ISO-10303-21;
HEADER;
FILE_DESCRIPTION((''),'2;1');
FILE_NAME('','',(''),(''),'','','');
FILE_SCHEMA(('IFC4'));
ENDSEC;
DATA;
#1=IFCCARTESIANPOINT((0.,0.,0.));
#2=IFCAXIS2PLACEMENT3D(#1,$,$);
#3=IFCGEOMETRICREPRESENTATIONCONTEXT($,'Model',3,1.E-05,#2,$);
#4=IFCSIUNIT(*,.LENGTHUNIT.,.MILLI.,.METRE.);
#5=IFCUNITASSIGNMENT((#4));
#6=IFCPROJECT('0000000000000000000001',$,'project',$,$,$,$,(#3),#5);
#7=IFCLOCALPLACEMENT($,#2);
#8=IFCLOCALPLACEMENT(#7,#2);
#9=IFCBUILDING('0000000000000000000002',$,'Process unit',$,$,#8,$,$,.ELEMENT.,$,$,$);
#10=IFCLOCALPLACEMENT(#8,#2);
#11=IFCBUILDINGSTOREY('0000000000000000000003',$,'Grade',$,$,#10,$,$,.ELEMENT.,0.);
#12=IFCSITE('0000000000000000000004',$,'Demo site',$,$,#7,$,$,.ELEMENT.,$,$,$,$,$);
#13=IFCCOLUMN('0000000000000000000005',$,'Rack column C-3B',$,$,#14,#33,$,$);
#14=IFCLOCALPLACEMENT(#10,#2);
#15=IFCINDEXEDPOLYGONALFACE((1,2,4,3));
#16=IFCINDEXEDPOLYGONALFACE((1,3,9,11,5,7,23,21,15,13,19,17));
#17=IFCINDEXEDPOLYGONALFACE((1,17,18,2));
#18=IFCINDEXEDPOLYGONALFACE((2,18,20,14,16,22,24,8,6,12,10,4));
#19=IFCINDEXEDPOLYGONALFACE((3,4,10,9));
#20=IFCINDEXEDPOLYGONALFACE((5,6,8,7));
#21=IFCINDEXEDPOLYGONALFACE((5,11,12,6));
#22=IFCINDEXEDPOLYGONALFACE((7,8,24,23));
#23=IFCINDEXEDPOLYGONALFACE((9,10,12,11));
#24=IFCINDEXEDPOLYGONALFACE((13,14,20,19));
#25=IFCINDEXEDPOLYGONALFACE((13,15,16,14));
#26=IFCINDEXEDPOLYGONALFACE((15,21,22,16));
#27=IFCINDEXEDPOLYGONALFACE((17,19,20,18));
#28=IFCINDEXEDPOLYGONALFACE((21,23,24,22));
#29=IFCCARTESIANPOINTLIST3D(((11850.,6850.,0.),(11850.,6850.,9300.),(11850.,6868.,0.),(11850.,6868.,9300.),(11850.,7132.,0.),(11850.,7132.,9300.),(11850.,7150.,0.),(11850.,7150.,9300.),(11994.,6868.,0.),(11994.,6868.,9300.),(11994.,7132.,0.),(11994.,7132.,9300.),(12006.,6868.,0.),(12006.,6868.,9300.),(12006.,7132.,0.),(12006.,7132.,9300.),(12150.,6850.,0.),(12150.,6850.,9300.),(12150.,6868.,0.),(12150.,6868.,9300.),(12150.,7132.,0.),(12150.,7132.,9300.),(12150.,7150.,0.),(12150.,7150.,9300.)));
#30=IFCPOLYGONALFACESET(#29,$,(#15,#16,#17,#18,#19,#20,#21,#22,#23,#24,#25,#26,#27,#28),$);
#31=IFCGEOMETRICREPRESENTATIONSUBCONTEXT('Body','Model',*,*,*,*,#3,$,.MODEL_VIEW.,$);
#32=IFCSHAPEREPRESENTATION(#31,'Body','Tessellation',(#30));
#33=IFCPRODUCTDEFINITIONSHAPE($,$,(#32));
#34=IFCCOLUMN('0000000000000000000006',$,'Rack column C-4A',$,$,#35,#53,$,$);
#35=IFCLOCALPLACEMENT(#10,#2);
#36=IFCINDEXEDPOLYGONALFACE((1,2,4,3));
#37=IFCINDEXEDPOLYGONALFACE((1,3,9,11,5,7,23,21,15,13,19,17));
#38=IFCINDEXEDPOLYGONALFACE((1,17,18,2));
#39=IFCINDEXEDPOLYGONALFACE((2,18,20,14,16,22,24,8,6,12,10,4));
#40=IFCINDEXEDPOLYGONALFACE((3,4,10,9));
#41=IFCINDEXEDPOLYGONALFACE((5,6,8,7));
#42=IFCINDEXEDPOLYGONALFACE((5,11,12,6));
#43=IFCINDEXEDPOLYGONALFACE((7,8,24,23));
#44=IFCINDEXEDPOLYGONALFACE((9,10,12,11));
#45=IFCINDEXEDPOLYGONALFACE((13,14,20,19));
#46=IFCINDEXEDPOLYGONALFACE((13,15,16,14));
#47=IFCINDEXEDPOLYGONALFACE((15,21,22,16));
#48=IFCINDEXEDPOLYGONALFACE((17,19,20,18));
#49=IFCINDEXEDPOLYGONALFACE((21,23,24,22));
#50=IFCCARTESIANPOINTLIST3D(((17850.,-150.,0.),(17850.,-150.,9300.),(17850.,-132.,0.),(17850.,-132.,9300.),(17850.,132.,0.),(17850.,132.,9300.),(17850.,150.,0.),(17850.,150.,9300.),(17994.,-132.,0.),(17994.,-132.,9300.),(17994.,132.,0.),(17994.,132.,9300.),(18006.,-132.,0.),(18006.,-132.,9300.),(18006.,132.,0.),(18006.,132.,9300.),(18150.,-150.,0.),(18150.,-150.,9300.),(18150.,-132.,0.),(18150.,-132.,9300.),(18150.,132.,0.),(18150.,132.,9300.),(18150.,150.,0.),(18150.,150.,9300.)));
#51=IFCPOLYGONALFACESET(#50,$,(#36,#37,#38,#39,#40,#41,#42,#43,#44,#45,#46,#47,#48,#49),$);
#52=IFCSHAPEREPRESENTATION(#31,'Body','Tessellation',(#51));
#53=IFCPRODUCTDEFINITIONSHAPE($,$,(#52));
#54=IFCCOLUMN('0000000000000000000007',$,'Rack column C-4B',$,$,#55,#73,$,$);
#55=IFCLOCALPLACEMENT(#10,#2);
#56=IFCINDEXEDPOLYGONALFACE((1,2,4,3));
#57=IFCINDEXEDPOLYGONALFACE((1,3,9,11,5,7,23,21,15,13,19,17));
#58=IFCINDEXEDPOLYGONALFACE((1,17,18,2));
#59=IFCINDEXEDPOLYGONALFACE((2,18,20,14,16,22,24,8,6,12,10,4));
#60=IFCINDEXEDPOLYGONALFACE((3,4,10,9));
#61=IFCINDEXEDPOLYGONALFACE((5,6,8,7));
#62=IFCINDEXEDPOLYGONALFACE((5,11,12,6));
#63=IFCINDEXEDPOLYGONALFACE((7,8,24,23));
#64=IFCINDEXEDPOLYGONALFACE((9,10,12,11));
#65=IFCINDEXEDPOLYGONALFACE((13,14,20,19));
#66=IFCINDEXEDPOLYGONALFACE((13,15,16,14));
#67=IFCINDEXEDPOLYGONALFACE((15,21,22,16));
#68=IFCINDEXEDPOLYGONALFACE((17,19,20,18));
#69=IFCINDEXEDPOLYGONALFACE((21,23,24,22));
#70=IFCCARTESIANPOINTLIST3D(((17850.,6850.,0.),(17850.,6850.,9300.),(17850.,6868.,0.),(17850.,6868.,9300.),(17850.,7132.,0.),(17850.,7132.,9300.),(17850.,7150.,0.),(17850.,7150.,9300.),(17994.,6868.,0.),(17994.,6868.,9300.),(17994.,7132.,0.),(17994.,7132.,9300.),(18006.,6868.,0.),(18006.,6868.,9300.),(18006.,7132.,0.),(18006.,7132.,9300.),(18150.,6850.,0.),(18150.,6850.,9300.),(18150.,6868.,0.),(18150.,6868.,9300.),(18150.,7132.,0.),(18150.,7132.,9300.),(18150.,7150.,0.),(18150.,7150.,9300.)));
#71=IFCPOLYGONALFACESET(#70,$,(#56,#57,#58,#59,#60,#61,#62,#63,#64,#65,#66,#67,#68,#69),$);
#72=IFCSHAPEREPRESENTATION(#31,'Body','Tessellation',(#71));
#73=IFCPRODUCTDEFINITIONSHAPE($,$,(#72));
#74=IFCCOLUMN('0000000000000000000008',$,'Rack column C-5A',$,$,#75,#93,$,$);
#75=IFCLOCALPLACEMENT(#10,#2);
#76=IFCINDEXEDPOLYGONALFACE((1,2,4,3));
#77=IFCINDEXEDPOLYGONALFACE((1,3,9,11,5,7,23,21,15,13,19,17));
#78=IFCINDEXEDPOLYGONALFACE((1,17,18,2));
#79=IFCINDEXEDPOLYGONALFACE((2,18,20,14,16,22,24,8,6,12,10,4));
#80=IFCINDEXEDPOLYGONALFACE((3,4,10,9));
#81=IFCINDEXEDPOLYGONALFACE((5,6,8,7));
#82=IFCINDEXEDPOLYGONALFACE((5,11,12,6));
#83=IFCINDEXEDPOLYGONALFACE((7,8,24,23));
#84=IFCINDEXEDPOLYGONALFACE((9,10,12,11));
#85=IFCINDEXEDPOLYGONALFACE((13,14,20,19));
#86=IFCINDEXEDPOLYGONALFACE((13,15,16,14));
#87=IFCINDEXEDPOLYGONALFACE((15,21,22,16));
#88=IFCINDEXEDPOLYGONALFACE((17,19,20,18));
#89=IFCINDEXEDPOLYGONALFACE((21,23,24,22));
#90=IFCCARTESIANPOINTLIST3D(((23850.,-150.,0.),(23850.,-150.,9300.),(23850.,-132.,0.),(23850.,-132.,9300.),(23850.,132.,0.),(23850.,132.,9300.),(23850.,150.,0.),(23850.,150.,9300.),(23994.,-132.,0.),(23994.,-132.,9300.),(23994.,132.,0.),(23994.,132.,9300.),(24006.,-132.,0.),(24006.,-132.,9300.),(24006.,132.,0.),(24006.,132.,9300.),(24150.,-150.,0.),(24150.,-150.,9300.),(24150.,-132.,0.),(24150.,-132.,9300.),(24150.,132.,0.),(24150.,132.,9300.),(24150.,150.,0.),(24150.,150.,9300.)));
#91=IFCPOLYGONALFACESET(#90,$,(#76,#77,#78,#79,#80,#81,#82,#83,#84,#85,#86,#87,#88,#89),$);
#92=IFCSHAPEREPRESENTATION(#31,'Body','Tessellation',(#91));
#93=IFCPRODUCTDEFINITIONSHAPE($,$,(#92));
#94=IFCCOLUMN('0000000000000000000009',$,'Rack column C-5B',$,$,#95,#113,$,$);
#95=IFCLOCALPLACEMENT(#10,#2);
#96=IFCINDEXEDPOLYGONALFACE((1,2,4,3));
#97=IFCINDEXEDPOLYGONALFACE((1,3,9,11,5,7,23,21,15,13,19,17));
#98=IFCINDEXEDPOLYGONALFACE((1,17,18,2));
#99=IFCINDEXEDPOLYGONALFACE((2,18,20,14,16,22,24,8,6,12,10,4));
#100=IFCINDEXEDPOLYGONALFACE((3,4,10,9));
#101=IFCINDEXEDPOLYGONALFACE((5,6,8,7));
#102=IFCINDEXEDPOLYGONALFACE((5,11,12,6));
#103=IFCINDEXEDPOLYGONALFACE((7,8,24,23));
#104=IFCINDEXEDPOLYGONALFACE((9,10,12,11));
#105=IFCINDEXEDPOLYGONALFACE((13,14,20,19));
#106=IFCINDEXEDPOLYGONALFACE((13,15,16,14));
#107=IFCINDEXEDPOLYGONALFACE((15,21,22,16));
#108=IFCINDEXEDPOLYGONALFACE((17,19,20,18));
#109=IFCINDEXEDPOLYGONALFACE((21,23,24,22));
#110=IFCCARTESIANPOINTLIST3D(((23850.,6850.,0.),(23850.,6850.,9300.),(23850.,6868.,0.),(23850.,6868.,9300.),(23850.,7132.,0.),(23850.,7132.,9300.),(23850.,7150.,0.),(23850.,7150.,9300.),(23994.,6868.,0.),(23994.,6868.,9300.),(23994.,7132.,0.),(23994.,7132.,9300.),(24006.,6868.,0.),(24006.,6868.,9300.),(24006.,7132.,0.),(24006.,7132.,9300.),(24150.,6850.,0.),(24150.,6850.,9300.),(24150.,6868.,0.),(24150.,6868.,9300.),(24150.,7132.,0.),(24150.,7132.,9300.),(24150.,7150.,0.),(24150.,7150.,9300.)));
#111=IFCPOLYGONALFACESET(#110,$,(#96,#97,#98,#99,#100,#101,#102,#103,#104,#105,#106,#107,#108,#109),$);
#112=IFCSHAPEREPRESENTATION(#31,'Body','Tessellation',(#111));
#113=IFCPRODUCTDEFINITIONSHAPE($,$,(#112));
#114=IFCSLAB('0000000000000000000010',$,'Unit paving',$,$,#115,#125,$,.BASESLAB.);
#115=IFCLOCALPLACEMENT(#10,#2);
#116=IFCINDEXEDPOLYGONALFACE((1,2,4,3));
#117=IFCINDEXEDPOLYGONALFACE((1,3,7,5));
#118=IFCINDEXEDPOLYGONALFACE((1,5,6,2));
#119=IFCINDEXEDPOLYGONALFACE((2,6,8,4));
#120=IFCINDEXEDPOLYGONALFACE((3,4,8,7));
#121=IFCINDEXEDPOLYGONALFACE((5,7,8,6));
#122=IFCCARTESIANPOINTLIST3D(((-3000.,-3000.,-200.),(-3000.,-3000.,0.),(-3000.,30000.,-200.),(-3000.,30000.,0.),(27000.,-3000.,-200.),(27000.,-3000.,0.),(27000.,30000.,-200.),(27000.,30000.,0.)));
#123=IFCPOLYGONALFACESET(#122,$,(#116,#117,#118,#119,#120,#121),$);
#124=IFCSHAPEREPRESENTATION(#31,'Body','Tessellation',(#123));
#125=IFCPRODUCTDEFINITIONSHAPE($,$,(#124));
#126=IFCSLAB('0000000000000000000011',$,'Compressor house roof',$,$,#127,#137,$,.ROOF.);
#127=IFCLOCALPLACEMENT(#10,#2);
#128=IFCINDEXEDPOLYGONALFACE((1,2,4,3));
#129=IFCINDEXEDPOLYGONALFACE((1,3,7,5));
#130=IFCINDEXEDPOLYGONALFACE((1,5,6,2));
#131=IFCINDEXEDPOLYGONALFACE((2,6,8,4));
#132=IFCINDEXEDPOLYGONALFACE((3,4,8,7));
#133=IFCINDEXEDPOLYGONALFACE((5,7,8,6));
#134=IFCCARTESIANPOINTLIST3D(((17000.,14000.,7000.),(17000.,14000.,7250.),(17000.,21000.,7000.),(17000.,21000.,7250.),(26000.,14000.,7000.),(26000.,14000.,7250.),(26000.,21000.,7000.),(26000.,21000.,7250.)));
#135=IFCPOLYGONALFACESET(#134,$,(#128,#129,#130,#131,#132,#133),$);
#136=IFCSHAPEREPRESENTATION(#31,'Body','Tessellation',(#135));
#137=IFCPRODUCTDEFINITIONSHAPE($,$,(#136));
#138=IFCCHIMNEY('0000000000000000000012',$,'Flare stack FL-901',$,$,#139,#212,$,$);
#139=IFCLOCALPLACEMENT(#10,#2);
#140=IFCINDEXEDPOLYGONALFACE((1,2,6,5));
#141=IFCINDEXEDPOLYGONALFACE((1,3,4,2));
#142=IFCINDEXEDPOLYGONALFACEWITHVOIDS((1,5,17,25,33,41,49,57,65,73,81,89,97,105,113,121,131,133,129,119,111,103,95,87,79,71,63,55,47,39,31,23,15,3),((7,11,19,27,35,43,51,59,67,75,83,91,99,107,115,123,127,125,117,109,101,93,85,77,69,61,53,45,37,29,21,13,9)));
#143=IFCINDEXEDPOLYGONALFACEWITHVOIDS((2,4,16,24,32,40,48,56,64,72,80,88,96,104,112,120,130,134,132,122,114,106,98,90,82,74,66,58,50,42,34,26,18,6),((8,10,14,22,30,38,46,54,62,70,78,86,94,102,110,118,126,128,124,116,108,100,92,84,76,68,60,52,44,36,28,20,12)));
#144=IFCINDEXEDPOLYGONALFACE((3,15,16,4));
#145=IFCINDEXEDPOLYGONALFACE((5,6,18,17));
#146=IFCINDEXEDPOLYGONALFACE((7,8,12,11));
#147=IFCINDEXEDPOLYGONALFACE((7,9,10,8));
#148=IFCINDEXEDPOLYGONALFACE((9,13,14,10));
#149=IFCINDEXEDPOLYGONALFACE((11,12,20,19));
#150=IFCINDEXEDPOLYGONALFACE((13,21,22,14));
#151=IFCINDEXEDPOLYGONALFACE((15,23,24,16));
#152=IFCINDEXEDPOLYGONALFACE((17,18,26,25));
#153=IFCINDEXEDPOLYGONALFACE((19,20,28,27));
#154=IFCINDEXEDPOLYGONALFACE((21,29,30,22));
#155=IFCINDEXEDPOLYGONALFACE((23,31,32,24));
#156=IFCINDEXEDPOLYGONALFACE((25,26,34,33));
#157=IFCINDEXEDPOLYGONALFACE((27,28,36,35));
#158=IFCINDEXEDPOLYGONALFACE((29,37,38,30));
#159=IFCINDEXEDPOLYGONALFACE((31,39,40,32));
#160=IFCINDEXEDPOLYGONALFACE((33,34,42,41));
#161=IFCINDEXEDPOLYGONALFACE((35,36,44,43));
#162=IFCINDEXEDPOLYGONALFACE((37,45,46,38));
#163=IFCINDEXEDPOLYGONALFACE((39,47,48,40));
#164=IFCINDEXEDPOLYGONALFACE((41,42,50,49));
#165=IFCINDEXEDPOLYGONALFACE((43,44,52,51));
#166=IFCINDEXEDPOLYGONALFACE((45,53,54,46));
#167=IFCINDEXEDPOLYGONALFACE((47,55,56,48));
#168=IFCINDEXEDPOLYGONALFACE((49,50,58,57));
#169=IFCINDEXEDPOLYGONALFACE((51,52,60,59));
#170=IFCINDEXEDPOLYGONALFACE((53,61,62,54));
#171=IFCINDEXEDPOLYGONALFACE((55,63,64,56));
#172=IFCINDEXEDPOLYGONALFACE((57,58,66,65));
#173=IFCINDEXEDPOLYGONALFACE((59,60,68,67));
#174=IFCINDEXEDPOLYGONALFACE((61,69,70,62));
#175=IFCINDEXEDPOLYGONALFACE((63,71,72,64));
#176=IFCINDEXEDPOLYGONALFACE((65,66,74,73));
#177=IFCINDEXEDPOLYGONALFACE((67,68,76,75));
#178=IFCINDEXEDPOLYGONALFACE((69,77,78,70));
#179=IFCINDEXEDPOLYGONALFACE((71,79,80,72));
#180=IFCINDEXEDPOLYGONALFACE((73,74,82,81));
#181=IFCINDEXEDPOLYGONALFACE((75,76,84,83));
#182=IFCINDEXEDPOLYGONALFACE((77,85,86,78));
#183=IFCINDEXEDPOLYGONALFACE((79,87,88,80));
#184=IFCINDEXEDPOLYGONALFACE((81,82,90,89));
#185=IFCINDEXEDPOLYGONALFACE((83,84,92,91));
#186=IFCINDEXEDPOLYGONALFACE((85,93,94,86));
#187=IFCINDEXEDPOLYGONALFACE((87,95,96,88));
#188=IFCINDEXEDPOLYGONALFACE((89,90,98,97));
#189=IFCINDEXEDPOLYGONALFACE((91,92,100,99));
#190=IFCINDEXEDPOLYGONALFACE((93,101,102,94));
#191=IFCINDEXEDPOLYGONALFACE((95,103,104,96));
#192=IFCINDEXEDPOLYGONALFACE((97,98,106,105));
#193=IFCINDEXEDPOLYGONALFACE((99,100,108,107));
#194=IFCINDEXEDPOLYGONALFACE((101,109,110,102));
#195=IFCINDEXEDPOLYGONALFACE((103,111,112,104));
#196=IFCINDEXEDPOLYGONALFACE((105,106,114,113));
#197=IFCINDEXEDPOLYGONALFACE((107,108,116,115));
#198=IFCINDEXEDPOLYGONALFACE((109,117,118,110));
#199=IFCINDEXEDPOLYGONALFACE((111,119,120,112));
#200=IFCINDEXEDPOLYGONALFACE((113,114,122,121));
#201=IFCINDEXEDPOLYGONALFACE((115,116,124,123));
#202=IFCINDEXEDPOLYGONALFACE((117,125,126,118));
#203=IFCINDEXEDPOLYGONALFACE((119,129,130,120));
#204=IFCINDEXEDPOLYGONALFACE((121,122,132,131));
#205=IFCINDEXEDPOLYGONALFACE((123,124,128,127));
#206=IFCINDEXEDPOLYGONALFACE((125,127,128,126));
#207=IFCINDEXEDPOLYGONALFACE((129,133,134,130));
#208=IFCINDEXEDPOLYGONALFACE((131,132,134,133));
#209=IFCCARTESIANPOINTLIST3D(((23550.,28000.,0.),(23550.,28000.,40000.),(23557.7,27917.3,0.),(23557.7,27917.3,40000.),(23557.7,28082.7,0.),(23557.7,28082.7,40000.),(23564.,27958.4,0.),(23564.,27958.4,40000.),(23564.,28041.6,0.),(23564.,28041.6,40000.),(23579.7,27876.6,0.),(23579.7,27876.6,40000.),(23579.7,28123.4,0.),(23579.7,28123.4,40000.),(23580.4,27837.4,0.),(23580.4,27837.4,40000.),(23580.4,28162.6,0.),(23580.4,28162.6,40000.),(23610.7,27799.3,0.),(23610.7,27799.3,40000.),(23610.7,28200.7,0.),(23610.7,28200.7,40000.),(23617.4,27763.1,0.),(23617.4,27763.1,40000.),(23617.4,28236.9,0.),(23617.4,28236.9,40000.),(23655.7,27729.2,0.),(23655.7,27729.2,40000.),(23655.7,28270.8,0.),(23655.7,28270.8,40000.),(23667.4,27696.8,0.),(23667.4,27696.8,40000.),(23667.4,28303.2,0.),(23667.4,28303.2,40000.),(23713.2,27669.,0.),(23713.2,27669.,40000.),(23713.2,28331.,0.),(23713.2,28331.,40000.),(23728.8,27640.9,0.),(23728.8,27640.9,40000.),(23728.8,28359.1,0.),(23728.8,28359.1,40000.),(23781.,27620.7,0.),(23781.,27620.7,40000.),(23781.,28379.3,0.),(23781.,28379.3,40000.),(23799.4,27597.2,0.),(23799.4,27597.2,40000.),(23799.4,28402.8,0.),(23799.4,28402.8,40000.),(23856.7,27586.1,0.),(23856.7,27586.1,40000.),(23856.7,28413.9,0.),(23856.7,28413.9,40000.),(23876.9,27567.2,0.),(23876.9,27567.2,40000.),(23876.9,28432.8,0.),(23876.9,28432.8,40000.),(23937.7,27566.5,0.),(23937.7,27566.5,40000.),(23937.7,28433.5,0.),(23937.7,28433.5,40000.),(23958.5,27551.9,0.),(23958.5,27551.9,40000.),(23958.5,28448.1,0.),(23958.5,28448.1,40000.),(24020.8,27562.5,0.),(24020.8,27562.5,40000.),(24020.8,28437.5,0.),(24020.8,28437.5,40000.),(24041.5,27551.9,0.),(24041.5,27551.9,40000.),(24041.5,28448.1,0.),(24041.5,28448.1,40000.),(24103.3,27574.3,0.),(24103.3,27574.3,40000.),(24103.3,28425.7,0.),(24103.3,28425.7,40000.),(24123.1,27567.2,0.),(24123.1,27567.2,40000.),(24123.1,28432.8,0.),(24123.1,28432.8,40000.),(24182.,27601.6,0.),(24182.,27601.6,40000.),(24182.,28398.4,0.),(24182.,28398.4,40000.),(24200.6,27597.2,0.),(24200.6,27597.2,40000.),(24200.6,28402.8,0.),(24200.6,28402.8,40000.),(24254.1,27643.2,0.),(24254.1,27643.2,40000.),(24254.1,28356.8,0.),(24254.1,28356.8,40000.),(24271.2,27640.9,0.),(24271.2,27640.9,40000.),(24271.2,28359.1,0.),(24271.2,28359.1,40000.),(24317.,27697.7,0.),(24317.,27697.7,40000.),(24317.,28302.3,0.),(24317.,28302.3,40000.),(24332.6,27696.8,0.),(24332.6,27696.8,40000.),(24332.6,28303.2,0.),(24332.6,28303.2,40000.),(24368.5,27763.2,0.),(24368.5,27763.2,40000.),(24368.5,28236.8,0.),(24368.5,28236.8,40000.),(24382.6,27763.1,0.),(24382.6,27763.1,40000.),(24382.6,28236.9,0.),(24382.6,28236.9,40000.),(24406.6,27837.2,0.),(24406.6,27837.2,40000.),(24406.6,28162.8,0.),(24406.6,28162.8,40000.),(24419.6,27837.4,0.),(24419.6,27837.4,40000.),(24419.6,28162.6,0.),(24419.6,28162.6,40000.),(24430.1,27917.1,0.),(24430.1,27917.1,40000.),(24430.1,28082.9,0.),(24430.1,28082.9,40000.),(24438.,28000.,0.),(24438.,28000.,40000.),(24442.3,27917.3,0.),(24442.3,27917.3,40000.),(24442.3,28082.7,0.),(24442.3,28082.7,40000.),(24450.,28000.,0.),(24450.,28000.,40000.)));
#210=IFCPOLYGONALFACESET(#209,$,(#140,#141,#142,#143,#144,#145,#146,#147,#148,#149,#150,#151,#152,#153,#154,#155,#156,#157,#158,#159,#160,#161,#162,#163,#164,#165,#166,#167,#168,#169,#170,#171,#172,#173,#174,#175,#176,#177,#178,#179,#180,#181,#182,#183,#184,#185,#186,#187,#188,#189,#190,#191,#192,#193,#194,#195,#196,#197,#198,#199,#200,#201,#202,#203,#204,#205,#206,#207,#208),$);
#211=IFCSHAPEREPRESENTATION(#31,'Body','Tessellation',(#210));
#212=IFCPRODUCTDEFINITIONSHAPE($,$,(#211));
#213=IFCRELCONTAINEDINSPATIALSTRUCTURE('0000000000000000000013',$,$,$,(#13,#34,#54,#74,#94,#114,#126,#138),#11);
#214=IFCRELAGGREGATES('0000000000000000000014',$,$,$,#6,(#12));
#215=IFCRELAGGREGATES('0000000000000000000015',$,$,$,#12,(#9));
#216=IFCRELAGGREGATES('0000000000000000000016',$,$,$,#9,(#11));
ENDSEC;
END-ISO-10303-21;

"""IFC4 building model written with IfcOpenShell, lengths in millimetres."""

from ifc_helpers import new_model, si_unit, frame, origin, place, context, subcontext, project, spatial, polyline, hollow_circle, i_section, outline, extrude, element, save


model = new_model("IFC4")

# Units and contexts
model_context = context("Model", 3, precision=1e-05, world=origin())
body_context = subcontext(model_context, "Body", "Model", "MODEL_VIEW")
ifc_project = project(units=[si_unit("LENGTHUNIT", "METRE", prefix="MILLI")], contexts=[model_context])

# Site, building, storey
site_placement = place(None, origin())
site = spatial("IfcSite", under=ifc_project, at=site_placement, Name="Demo site", CompositionType="ELEMENT")
building_placement = place(site_placement, origin())
building = spatial("IfcBuilding", under=site, at=building_placement, Name="Process unit", CompositionType="ELEMENT")
storey_placement = place(building_placement, origin())
storey = spatial("IfcBuildingStorey", under=building, at=storey_placement, Name="Grade", CompositionType="ELEMENT", Elevation=0.0)

# Columns
for number, where, name in (
    (1, (12000.0, 7000.0, 0.0), "Rack column C-3B"),
    (2, (18000.0, 0.0, 0.0), "Rack column C-4A"),
    (3, (18000.0, 7000.0, 0.0), "Rack column C-4B"),
    (4, (24000.0, 0.0, 0.0), "Rack column C-5A"),
    (5, (24000.0, 7000.0, 0.0), "Rack column C-5B"),
):
    element("IfcColumn", number, at=place(storey_placement, frame(where)), inside=storey, Name=name, context=body_context, shape_type="SweptSolid", body=[
        extrude(i_section(OverallWidth=300.0, OverallDepth=300.0, WebThickness=12.0, FlangeThickness=18.0), origin(), (0.0, 0.0, 1.0), 9300.0),
    ])

# Slabs
slab_1_placement = place(storey_placement, frame((0.0, 0.0, -200.0)))
element("IfcSlab", 6, at=slab_1_placement, inside=storey, Name="Unit paving", PredefinedType="BASESLAB", context=body_context, shape_type="SweptSolid", body=[
    extrude(outline(polyline([(-3000.0, -3000.0), (27000.0, -3000.0), (27000.0, 30000.0), (-3000.0, 30000.0), (-3000.0, -3000.0)])), origin(), (0.0, 0.0, 1.0), 200.0),
])
slab_2_placement = place(storey_placement, frame((17000.0, 14000.0, 7000.0)))
element("IfcSlab", 7, at=slab_2_placement, inside=storey, Name="Compressor house roof", PredefinedType="ROOF", context=body_context, shape_type="SweptSolid", body=[
    extrude(outline(polyline([(0.0, 0.0), (9000.0, 0.0), (9000.0, 7000.0), (0.0, 7000.0), (0.0, 0.0)])), origin(), (0.0, 0.0, 1.0), 250.0),
])

# Chimney
chimney_placement = place(storey_placement, frame((24000.0, 28000.0, 0.0)))
element("IfcChimney", 8, at=chimney_placement, inside=storey, Name="Flare stack FL-901", context=body_context, shape_type="SweptSolid", body=[
    extrude(hollow_circle(Radius=450.0, WallThickness=12.0), origin(), (0.0, 0.0, 1.0), 40000.0),
])

save(model, "model.ifc")
